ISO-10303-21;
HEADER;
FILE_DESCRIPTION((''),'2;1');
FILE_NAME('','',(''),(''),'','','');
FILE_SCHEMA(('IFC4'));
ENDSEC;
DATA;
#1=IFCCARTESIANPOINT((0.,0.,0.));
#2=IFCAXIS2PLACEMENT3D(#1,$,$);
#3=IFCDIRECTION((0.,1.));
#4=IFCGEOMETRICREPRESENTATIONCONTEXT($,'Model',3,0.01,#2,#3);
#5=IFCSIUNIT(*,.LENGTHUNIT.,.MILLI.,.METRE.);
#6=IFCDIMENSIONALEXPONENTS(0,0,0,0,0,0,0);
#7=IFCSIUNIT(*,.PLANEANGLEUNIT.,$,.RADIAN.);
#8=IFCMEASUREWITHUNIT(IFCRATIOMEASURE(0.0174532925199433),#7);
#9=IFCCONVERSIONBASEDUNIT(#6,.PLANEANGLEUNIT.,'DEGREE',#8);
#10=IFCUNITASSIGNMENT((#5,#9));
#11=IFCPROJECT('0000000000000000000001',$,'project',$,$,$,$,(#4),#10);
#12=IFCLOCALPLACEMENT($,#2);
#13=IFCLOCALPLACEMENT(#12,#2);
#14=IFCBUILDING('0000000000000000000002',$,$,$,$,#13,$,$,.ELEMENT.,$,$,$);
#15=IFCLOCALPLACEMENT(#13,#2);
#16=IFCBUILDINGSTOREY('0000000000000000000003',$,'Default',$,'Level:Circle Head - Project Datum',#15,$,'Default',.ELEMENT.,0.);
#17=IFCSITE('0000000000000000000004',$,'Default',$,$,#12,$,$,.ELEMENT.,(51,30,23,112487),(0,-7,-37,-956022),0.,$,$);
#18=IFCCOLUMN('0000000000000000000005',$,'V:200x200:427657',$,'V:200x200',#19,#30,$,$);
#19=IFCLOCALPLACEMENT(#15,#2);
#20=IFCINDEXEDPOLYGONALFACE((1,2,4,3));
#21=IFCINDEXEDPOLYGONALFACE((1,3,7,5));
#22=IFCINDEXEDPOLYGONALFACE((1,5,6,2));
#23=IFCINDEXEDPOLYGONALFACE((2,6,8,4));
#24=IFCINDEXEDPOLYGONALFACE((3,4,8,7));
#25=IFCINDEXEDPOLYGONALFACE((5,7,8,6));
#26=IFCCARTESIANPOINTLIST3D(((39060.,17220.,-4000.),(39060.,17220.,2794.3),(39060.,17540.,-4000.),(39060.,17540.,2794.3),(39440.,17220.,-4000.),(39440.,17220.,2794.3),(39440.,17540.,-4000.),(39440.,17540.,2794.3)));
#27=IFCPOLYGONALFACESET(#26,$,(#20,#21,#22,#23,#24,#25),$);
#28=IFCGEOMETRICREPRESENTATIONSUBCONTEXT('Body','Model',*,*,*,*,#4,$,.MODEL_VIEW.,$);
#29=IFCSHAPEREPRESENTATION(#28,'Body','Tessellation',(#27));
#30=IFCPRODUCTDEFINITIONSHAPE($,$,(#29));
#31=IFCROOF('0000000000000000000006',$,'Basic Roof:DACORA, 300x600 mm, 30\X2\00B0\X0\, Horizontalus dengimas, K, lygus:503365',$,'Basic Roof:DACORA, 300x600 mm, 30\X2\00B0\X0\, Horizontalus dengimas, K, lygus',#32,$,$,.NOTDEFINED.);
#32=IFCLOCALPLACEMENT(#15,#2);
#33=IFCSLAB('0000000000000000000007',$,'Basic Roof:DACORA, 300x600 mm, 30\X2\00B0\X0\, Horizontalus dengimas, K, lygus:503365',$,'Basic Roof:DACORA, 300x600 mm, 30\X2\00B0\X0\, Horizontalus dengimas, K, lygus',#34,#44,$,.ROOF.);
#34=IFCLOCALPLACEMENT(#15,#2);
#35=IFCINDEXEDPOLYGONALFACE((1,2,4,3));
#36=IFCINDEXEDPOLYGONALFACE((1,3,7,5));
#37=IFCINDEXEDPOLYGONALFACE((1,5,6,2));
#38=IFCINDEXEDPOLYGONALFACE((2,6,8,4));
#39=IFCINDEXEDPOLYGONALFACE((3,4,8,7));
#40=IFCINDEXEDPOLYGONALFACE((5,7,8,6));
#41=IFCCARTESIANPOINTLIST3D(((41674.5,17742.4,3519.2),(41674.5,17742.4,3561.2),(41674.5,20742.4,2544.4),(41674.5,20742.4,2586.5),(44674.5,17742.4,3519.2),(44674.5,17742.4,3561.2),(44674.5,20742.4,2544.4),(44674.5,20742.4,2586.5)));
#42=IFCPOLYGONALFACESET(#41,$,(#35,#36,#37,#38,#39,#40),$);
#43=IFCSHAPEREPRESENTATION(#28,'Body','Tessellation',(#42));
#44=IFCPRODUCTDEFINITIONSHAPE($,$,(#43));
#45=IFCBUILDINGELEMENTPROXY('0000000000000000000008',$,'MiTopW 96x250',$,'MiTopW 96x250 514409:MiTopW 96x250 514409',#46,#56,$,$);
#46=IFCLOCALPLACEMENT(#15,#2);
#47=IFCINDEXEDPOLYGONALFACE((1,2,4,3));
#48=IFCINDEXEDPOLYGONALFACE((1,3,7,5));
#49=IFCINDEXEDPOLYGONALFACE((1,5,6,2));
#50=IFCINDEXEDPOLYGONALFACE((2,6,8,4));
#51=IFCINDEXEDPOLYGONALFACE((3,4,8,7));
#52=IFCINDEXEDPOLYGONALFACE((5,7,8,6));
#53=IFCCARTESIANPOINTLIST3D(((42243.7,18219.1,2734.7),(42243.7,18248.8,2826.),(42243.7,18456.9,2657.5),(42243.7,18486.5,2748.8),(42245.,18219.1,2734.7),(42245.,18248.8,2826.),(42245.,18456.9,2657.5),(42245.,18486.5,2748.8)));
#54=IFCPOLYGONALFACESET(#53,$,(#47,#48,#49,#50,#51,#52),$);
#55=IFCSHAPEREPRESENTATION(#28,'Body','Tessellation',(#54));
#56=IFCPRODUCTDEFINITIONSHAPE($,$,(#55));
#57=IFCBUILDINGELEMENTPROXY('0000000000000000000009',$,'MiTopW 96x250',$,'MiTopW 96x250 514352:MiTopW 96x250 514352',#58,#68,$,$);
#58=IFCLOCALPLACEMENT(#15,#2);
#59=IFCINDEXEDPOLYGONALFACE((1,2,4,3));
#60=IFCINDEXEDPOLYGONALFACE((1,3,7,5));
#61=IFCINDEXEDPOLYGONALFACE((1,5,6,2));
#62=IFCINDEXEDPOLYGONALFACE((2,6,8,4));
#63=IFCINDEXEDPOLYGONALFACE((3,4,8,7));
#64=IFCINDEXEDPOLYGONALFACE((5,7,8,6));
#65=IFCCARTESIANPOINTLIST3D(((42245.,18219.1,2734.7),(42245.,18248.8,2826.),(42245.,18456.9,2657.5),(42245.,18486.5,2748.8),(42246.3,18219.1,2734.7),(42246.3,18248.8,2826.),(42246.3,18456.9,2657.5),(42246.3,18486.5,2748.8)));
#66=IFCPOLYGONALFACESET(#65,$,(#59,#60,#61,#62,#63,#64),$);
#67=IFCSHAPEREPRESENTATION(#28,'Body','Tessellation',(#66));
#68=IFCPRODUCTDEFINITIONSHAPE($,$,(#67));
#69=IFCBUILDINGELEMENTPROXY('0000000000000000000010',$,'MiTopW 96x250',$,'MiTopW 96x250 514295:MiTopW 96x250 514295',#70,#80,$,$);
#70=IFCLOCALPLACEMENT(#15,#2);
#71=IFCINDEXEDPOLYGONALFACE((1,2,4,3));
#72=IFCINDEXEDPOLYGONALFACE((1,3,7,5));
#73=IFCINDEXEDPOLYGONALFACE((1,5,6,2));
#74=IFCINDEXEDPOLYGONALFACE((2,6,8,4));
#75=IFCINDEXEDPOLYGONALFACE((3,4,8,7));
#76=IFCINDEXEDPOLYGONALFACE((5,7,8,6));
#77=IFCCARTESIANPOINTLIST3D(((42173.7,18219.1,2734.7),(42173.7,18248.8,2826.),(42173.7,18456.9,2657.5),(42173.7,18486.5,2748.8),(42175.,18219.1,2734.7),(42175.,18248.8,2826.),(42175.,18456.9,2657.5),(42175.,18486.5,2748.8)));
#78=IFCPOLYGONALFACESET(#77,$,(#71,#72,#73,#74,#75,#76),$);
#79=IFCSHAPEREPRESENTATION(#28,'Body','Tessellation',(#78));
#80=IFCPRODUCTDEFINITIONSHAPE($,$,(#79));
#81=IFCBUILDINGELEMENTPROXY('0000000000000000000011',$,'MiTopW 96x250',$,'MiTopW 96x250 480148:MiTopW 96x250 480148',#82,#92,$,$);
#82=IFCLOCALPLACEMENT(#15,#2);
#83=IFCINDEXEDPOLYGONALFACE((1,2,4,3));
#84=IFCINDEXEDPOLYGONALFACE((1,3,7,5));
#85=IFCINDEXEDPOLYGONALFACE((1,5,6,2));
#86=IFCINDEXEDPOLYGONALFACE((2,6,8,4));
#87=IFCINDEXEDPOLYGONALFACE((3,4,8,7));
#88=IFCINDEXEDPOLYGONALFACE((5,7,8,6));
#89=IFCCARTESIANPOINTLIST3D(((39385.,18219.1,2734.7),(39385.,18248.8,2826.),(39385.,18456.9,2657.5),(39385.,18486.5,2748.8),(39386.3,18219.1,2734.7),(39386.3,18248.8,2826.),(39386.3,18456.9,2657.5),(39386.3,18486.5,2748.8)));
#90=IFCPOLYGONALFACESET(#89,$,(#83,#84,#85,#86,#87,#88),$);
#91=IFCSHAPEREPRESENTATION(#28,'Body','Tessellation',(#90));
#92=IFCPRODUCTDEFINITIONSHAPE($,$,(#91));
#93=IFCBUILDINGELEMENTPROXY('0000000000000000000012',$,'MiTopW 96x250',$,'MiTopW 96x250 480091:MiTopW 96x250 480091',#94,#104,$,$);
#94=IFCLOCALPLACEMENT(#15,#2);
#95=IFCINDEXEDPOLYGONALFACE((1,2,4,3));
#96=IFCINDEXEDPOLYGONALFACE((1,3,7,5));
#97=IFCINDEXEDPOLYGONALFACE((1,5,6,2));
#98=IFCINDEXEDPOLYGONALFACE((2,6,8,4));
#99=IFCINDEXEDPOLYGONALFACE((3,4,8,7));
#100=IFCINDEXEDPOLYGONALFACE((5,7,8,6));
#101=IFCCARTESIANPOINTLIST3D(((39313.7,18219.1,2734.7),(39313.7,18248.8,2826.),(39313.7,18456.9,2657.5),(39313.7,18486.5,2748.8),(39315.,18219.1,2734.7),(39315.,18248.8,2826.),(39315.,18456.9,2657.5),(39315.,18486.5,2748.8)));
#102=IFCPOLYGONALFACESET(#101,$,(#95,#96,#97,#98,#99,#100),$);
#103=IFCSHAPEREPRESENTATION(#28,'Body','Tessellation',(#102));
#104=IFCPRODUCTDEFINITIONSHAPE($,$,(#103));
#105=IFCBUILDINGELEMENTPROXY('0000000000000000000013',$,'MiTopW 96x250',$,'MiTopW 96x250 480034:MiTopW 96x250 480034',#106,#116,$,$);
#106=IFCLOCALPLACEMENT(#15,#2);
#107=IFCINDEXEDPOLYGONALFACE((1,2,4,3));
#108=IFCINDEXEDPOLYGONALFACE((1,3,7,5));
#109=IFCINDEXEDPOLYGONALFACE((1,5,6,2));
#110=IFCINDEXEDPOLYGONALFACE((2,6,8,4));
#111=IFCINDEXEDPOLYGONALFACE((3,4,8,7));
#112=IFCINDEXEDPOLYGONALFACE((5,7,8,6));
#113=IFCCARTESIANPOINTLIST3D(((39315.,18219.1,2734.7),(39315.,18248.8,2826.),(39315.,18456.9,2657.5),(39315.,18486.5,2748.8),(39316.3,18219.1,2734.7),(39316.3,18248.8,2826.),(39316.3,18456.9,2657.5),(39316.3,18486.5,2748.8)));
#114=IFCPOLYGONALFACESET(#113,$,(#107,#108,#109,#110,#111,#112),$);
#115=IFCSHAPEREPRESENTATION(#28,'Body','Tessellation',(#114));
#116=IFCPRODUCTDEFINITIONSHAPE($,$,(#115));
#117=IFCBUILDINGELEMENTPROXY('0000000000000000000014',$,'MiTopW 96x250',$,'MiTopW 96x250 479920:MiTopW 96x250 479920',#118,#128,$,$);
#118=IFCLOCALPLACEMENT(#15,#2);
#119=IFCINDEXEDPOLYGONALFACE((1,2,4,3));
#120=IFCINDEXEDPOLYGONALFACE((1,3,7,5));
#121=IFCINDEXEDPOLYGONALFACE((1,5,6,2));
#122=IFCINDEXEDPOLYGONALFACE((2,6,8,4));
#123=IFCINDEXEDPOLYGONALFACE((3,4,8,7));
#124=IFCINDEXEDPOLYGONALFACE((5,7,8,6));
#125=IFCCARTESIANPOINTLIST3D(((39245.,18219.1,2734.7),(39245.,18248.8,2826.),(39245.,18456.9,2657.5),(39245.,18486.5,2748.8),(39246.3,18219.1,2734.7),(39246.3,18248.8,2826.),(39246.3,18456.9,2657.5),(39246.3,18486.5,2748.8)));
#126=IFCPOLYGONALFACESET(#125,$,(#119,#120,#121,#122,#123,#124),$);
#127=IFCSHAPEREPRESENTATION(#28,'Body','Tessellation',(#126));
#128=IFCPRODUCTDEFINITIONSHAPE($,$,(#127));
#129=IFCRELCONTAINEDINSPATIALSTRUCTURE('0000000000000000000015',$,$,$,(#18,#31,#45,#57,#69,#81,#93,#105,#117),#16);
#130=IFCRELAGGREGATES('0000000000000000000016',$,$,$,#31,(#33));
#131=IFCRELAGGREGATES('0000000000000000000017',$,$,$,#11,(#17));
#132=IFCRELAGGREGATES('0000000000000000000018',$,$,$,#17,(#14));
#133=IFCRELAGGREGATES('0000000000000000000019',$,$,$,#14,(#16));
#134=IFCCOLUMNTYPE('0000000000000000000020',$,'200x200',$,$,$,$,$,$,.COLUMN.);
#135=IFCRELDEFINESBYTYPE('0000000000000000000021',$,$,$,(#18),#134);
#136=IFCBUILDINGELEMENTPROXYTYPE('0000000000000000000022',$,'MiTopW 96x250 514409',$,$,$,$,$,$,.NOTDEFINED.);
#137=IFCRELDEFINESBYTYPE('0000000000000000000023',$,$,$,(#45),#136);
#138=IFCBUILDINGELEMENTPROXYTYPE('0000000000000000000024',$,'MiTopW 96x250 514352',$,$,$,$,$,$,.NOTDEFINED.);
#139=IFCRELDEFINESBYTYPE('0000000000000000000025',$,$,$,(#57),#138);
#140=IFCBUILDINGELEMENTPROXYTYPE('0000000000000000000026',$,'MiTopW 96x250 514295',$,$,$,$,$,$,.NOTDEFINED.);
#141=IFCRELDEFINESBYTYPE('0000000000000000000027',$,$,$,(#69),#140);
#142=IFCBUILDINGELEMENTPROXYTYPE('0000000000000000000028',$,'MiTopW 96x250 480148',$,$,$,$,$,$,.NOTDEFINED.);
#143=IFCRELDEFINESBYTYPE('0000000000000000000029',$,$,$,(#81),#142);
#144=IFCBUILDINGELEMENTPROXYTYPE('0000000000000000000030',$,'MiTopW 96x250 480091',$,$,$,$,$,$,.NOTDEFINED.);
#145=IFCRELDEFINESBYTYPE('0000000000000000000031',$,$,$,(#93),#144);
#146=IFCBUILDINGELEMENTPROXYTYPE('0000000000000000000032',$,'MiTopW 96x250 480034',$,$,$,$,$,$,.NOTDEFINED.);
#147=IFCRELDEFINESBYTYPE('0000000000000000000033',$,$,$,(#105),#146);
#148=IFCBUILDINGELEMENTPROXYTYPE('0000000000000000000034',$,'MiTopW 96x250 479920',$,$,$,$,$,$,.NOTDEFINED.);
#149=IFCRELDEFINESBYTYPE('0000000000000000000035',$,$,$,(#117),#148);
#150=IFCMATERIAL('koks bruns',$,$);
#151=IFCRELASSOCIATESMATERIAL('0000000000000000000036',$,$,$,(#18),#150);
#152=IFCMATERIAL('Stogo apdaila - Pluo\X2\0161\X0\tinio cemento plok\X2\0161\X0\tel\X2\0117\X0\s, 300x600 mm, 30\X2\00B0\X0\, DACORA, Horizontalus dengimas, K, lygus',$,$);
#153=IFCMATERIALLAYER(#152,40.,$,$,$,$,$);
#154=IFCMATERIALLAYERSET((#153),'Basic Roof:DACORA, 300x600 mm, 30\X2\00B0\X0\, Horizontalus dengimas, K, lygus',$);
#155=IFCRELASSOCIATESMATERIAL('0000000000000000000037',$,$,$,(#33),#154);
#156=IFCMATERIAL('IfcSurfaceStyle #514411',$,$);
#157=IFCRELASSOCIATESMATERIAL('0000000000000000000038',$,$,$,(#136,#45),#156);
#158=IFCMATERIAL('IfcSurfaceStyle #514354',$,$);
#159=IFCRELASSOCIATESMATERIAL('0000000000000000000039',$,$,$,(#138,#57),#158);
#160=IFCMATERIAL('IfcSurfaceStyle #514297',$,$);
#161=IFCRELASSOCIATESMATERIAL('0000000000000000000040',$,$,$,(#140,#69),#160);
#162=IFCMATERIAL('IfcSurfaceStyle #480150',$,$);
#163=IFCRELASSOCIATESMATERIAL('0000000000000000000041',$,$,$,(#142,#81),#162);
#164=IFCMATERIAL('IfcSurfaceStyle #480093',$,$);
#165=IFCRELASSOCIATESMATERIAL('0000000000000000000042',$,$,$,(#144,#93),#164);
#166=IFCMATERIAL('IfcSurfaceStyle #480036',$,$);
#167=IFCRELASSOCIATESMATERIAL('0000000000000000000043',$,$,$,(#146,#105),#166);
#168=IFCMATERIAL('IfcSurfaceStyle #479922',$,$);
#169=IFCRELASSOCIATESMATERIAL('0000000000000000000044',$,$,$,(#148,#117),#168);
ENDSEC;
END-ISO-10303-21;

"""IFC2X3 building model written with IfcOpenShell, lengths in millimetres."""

from ifc_helpers import new_model, entity, si_unit, converted_unit, direction, frame, frame_2d, origin, origin_2d_with_axis, place, context, subcontext, project, spatial, polyline, rectangle, outline, extrude, source, transform, mapped, material, layer, layer_set, type_object, type_shapes, element, aggregate, save


model = new_model("IFC2X3")

# Units and contexts
model_context = context("Model", 3, precision=0.01, world=origin(), true_north=direction((0.0, 1.0)))
body_context = subcontext(model_context, "Body", "Model", "MODEL_VIEW")
ifc_project = project(units=[si_unit("LENGTHUNIT", "METRE", prefix="MILLI"), converted_unit("PLANEANGLEUNIT", "DEGREE", entity("IfcRatioMeasure", 0.0174532925199433), si_unit("PLANEANGLEUNIT", "RADIAN"), dimensions=[0, 0, 0, 0, 0, 0, 0])], contexts=[model_context])

# Site, building, storey
site_placement = place(None, origin())
site = spatial("IfcSite", under=ifc_project, at=site_placement, Name="Default", CompositionType="ELEMENT", RefLatitude=(51, 30, 23, 112487), RefLongitude=(0, -7, -37, -956022), RefElevation=0.0)
building_placement = place(site_placement, origin())
building = spatial("IfcBuilding", under=site, at=building_placement, CompositionType="ELEMENT")
storey_placement = place(building_placement, origin())
storey = spatial("IfcBuildingStorey", under=building, at=storey_placement, Name="Default", ObjectType="Level:Circle Head - Project Datum", LongName="Default", CompositionType="ELEMENT", Elevation=0.0)

# Column
ifc_material_1 = material(Name="koks bruns")
column_type_1 = type_object("IfcColumnType", Name="200x200", PredefinedType="COLUMN")
shared_shape_1 = source(origin(), body_context, "Body", "SweptSolid", [
    extrude(rectangle(XDim=380.0, YDim=320.0, at=origin_2d_with_axis()), frame((160.0, 300.0, -4000.0), z_axis=(0.0, 0.0, 1.0), x_axis=(0.0, -1.0, 0.0)), (0.0, 0.0, 1.0), 6794.3),
])
type_shapes(column_type_1, [shared_shape_1])
column_placement = place(storey_placement, frame((39550.0, 17220.0, 0.0), z_axis=(0.0, 0.0, 1.0), x_axis=(0.0, 1.0, 0.0)))
element("IfcColumn", 1, at=column_placement, inside=storey, type_object=column_type_1, material=ifc_material_1, Name="V:200x200:427657", ObjectType="V:200x200", context=body_context, shape_type="MappedRepresentation", body=[
    mapped(shared_shape_1, transform((0.0, 0.0, 0.0), scale=1.0)),
])

# Roof, slab
roof_placement = place(storey_placement, frame((41674.5, 17742.4, 2544.4)))
roof = element("IfcRoof", 2, at=roof_placement, inside=storey, Name="Basic Roof:DACORA, 300x600 mm, 30°, Horizontalus dengimas, K, lygus:503365", ObjectType="Basic Roof:DACORA, 300x600 mm, 30°, Horizontalus dengimas, K, lygus", ShapeType="NOTDEFINED")
ifc_material_2 = material(Name="Stogo apdaila - Pluoštinio cemento plokštelės, 300x600 mm, 30°, DACORA, Horizontalus dengimas, K, lygus")
ifc_layer = layer(ifc_material_2, 40.0)
ifc_layer_set = layer_set([ifc_layer], Name="Basic Roof:DACORA, 300x600 mm, 30°, Horizontalus dengimas, K, lygus")
slab_placement = place(roof_placement, origin())
slab = element("IfcSlab", 3, at=slab_placement, material=ifc_layer_set, Name="Basic Roof:DACORA, 300x600 mm, 30°, Horizontalus dengimas, K, lygus:503365", ObjectType="Basic Roof:DACORA, 300x600 mm, 30°, Horizontalus dengimas, K, lygus", PredefinedType="ROOF", context=body_context, shape_type="SweptSolid", body=[
    extrude(rectangle(XDim=3154.4, YDim=3000.0, at=frame_2d((0.0, 0.0), x_axis=(0.0, 1.0))), frame((1500.0, 1500.0, 487.4), z_axis=(0.0, 0.309017, 0.951057), x_axis=(1.0, 0.0, 0.0)), (0.0, -0.309017, 0.951057), 42.1),
])
aggregate(roof, [slab])

# Building element proxies
ifc_material_3 = material(Name="IfcSurfaceStyle #514411")
building_element_proxy_type_1 = type_object("IfcBuildingElementProxyType", Name="MiTopW 96x250 514409", PredefinedType="NOTDEFINED", material=ifc_material_3)
shared_shape_2 = source(origin(), body_context, "Body", "SweptSolid", [
    extrude(outline(polyline([(-125.0, -48.0), (125.0, -48.0), (125.0, 48.0), (-125.0, 48.0), (-125.0, -48.0)])), frame((125.0, 48.0, 0.0), z_axis=(0.0, 0.0, 1.0), x_axis=(-1.0, 0.0, 0.0)), (0.0, 0.0, 1.0), 1.3),
])
type_shapes(building_element_proxy_type_1, [shared_shape_2])
proxy_1_placement = place(building_placement, frame((42245.0, 18456.9, 2657.5), z_axis=(-1.0, 0.0, 0.0), x_axis=(0.0, -0.951057, 0.309017)))
element("IfcBuildingElementProxy", 4, at=proxy_1_placement, inside=storey, type_object=building_element_proxy_type_1, material=ifc_material_3, Name="MiTopW 96x250", ObjectType="MiTopW 96x250 514409:MiTopW 96x250 514409", context=body_context, shape_type="MappedRepresentation", body=[
    mapped(shared_shape_2, transform((0.0, 0.0, 0.0), scale=1.0)),
])
ifc_material_4 = material(Name="IfcSurfaceStyle #514354")
building_element_proxy_type_2 = type_object("IfcBuildingElementProxyType", Name="MiTopW 96x250 514352", PredefinedType="NOTDEFINED", material=ifc_material_4)
shared_shape_3 = source(origin(), body_context, "Body", "SweptSolid", [
    extrude(outline(polyline([(-125.0, -48.0), (125.0, -48.0), (125.0, 48.0), (-125.0, 48.0), (-125.0, -48.0)])), frame((125.0, 48.0, 0.0), z_axis=(0.0, 0.0, 1.0), x_axis=(-1.0, 0.0, 0.0)), (0.0, 0.0, 1.0), 1.3),
])
type_shapes(building_element_proxy_type_2, [shared_shape_3])
proxy_2_placement = place(building_placement, frame((42246.3, 18456.9, 2657.5), z_axis=(-1.0, 0.0, 0.0), x_axis=(0.0, -0.951057, 0.309017)))
element("IfcBuildingElementProxy", 5, at=proxy_2_placement, inside=storey, type_object=building_element_proxy_type_2, material=ifc_material_4, Name="MiTopW 96x250", ObjectType="MiTopW 96x250 514352:MiTopW 96x250 514352", context=body_context, shape_type="MappedRepresentation", body=[
    mapped(shared_shape_3, transform((0.0, 0.0, 0.0), scale=1.0)),
])
ifc_material_5 = material(Name="IfcSurfaceStyle #514297")
building_element_proxy_type_3 = type_object("IfcBuildingElementProxyType", Name="MiTopW 96x250 514295", PredefinedType="NOTDEFINED", material=ifc_material_5)
shared_shape_4 = source(origin(), body_context, "Body", "SweptSolid", [
    extrude(outline(polyline([(-125.0, -48.0), (125.0, -48.0), (125.0, 48.0), (-125.0, 48.0), (-125.0, -48.0)])), frame((125.0, 48.0, 0.0), z_axis=(0.0, 0.0, 1.0), x_axis=(-1.0, 0.0, 0.0)), (0.0, 0.0, 1.0), 1.3),
])
type_shapes(building_element_proxy_type_3, [shared_shape_4])
proxy_3_placement = place(building_placement, frame((42175.0, 18456.9, 2657.5), z_axis=(-1.0, 0.0, 0.0), x_axis=(0.0, -0.951057, 0.309017)))
element("IfcBuildingElementProxy", 6, at=proxy_3_placement, inside=storey, type_object=building_element_proxy_type_3, material=ifc_material_5, Name="MiTopW 96x250", ObjectType="MiTopW 96x250 514295:MiTopW 96x250 514295", context=body_context, shape_type="MappedRepresentation", body=[
    mapped(shared_shape_4, transform((0.0, 0.0, 0.0), scale=1.0)),
])
ifc_material_6 = material(Name="IfcSurfaceStyle #480150")
building_element_proxy_type_4 = type_object("IfcBuildingElementProxyType", Name="MiTopW 96x250 480148", PredefinedType="NOTDEFINED", material=ifc_material_6)
shared_shape_5 = source(origin(), body_context, "Body", "SweptSolid", [
    extrude(outline(polyline([(-125.0, -48.0), (125.0, -48.0), (125.0, 48.0), (-125.0, 48.0), (-125.0, -48.0)])), frame((125.0, 48.0, 0.0), z_axis=(0.0, 0.0, 1.0), x_axis=(-1.0, 0.0, 0.0)), (0.0, 0.0, 1.0), 1.3),
])
type_shapes(building_element_proxy_type_4, [shared_shape_5])
proxy_4_placement = place(building_placement, frame((39386.3, 18456.9, 2657.5), z_axis=(-1.0, 0.0, 0.0), x_axis=(0.0, -0.951057, 0.309017)))
element("IfcBuildingElementProxy", 7, at=proxy_4_placement, inside=storey, type_object=building_element_proxy_type_4, material=ifc_material_6, Name="MiTopW 96x250", ObjectType="MiTopW 96x250 480148:MiTopW 96x250 480148", context=body_context, shape_type="MappedRepresentation", body=[
    mapped(shared_shape_5, transform((0.0, 0.0, 0.0), scale=1.0)),
])
ifc_material_7 = material(Name="IfcSurfaceStyle #480093")
building_element_proxy_type_5 = type_object("IfcBuildingElementProxyType", Name="MiTopW 96x250 480091", PredefinedType="NOTDEFINED", material=ifc_material_7)
shared_shape_6 = source(origin(), body_context, "Body", "SweptSolid", [
    extrude(outline(polyline([(-125.0, -48.0), (125.0, -48.0), (125.0, 48.0), (-125.0, 48.0), (-125.0, -48.0)])), frame((125.0, 48.0, 0.0), z_axis=(0.0, 0.0, 1.0), x_axis=(-1.0, 0.0, 0.0)), (0.0, 0.0, 1.0), 1.3),
])
type_shapes(building_element_proxy_type_5, [shared_shape_6])
proxy_5_placement = place(building_placement, frame((39315.0, 18456.9, 2657.5), z_axis=(-1.0, 0.0, 0.0), x_axis=(0.0, -0.951057, 0.309017)))
element("IfcBuildingElementProxy", 8, at=proxy_5_placement, inside=storey, type_object=building_element_proxy_type_5, material=ifc_material_7, Name="MiTopW 96x250", ObjectType="MiTopW 96x250 480091:MiTopW 96x250 480091", context=body_context, shape_type="MappedRepresentation", body=[
    mapped(shared_shape_6, transform((0.0, 0.0, 0.0), scale=1.0)),
])
ifc_material_8 = material(Name="IfcSurfaceStyle #480036")
building_element_proxy_type_6 = type_object("IfcBuildingElementProxyType", Name="MiTopW 96x250 480034", PredefinedType="NOTDEFINED", material=ifc_material_8)
shared_shape_7 = source(origin(), body_context, "Body", "SweptSolid", [
    extrude(outline(polyline([(-125.0, -48.0), (125.0, -48.0), (125.0, 48.0), (-125.0, 48.0), (-125.0, -48.0)])), frame((125.0, 48.0, 0.0), z_axis=(0.0, 0.0, 1.0), x_axis=(-1.0, 0.0, 0.0)), (0.0, 0.0, 1.0), 1.3),
])
type_shapes(building_element_proxy_type_6, [shared_shape_7])
proxy_6_placement = place(building_placement, frame((39316.3, 18456.9, 2657.5), z_axis=(-1.0, 0.0, 0.0), x_axis=(0.0, -0.951057, 0.309017)))
element("IfcBuildingElementProxy", 9, at=proxy_6_placement, inside=storey, type_object=building_element_proxy_type_6, material=ifc_material_8, Name="MiTopW 96x250", ObjectType="MiTopW 96x250 480034:MiTopW 96x250 480034", context=body_context, shape_type="MappedRepresentation", body=[
    mapped(shared_shape_7, transform((0.0, 0.0, 0.0), scale=1.0)),
])
ifc_material_9 = material(Name="IfcSurfaceStyle #479922")
building_element_proxy_type_7 = type_object("IfcBuildingElementProxyType", Name="MiTopW 96x250 479920", PredefinedType="NOTDEFINED", material=ifc_material_9)
shared_shape_8 = source(origin(), body_context, "Body", "SweptSolid", [
    extrude(outline(polyline([(-125.0, -48.0), (125.0, -48.0), (125.0, 48.0), (-125.0, 48.0), (-125.0, -48.0)])), frame((125.0, 48.0, 0.0), z_axis=(0.0, 0.0, 1.0), x_axis=(-1.0, 0.0, 0.0)), (0.0, 0.0, 1.0), 1.3),
])
type_shapes(building_element_proxy_type_7, [shared_shape_8])
proxy_7_placement = place(building_placement, frame((39246.3, 18456.9, 2657.5), z_axis=(-1.0, 0.0, 0.0), x_axis=(0.0, -0.951057, 0.309017)))
element("IfcBuildingElementProxy", 10, at=proxy_7_placement, inside=storey, type_object=building_element_proxy_type_7, material=ifc_material_9, Name="MiTopW 96x250", ObjectType="MiTopW 96x250 479920:MiTopW 96x250 479920", context=body_context, shape_type="MappedRepresentation", body=[
    mapped(shared_shape_8, transform((0.0, 0.0, 0.0), scale=1.0)),
])

save(model, "model.ifc")
